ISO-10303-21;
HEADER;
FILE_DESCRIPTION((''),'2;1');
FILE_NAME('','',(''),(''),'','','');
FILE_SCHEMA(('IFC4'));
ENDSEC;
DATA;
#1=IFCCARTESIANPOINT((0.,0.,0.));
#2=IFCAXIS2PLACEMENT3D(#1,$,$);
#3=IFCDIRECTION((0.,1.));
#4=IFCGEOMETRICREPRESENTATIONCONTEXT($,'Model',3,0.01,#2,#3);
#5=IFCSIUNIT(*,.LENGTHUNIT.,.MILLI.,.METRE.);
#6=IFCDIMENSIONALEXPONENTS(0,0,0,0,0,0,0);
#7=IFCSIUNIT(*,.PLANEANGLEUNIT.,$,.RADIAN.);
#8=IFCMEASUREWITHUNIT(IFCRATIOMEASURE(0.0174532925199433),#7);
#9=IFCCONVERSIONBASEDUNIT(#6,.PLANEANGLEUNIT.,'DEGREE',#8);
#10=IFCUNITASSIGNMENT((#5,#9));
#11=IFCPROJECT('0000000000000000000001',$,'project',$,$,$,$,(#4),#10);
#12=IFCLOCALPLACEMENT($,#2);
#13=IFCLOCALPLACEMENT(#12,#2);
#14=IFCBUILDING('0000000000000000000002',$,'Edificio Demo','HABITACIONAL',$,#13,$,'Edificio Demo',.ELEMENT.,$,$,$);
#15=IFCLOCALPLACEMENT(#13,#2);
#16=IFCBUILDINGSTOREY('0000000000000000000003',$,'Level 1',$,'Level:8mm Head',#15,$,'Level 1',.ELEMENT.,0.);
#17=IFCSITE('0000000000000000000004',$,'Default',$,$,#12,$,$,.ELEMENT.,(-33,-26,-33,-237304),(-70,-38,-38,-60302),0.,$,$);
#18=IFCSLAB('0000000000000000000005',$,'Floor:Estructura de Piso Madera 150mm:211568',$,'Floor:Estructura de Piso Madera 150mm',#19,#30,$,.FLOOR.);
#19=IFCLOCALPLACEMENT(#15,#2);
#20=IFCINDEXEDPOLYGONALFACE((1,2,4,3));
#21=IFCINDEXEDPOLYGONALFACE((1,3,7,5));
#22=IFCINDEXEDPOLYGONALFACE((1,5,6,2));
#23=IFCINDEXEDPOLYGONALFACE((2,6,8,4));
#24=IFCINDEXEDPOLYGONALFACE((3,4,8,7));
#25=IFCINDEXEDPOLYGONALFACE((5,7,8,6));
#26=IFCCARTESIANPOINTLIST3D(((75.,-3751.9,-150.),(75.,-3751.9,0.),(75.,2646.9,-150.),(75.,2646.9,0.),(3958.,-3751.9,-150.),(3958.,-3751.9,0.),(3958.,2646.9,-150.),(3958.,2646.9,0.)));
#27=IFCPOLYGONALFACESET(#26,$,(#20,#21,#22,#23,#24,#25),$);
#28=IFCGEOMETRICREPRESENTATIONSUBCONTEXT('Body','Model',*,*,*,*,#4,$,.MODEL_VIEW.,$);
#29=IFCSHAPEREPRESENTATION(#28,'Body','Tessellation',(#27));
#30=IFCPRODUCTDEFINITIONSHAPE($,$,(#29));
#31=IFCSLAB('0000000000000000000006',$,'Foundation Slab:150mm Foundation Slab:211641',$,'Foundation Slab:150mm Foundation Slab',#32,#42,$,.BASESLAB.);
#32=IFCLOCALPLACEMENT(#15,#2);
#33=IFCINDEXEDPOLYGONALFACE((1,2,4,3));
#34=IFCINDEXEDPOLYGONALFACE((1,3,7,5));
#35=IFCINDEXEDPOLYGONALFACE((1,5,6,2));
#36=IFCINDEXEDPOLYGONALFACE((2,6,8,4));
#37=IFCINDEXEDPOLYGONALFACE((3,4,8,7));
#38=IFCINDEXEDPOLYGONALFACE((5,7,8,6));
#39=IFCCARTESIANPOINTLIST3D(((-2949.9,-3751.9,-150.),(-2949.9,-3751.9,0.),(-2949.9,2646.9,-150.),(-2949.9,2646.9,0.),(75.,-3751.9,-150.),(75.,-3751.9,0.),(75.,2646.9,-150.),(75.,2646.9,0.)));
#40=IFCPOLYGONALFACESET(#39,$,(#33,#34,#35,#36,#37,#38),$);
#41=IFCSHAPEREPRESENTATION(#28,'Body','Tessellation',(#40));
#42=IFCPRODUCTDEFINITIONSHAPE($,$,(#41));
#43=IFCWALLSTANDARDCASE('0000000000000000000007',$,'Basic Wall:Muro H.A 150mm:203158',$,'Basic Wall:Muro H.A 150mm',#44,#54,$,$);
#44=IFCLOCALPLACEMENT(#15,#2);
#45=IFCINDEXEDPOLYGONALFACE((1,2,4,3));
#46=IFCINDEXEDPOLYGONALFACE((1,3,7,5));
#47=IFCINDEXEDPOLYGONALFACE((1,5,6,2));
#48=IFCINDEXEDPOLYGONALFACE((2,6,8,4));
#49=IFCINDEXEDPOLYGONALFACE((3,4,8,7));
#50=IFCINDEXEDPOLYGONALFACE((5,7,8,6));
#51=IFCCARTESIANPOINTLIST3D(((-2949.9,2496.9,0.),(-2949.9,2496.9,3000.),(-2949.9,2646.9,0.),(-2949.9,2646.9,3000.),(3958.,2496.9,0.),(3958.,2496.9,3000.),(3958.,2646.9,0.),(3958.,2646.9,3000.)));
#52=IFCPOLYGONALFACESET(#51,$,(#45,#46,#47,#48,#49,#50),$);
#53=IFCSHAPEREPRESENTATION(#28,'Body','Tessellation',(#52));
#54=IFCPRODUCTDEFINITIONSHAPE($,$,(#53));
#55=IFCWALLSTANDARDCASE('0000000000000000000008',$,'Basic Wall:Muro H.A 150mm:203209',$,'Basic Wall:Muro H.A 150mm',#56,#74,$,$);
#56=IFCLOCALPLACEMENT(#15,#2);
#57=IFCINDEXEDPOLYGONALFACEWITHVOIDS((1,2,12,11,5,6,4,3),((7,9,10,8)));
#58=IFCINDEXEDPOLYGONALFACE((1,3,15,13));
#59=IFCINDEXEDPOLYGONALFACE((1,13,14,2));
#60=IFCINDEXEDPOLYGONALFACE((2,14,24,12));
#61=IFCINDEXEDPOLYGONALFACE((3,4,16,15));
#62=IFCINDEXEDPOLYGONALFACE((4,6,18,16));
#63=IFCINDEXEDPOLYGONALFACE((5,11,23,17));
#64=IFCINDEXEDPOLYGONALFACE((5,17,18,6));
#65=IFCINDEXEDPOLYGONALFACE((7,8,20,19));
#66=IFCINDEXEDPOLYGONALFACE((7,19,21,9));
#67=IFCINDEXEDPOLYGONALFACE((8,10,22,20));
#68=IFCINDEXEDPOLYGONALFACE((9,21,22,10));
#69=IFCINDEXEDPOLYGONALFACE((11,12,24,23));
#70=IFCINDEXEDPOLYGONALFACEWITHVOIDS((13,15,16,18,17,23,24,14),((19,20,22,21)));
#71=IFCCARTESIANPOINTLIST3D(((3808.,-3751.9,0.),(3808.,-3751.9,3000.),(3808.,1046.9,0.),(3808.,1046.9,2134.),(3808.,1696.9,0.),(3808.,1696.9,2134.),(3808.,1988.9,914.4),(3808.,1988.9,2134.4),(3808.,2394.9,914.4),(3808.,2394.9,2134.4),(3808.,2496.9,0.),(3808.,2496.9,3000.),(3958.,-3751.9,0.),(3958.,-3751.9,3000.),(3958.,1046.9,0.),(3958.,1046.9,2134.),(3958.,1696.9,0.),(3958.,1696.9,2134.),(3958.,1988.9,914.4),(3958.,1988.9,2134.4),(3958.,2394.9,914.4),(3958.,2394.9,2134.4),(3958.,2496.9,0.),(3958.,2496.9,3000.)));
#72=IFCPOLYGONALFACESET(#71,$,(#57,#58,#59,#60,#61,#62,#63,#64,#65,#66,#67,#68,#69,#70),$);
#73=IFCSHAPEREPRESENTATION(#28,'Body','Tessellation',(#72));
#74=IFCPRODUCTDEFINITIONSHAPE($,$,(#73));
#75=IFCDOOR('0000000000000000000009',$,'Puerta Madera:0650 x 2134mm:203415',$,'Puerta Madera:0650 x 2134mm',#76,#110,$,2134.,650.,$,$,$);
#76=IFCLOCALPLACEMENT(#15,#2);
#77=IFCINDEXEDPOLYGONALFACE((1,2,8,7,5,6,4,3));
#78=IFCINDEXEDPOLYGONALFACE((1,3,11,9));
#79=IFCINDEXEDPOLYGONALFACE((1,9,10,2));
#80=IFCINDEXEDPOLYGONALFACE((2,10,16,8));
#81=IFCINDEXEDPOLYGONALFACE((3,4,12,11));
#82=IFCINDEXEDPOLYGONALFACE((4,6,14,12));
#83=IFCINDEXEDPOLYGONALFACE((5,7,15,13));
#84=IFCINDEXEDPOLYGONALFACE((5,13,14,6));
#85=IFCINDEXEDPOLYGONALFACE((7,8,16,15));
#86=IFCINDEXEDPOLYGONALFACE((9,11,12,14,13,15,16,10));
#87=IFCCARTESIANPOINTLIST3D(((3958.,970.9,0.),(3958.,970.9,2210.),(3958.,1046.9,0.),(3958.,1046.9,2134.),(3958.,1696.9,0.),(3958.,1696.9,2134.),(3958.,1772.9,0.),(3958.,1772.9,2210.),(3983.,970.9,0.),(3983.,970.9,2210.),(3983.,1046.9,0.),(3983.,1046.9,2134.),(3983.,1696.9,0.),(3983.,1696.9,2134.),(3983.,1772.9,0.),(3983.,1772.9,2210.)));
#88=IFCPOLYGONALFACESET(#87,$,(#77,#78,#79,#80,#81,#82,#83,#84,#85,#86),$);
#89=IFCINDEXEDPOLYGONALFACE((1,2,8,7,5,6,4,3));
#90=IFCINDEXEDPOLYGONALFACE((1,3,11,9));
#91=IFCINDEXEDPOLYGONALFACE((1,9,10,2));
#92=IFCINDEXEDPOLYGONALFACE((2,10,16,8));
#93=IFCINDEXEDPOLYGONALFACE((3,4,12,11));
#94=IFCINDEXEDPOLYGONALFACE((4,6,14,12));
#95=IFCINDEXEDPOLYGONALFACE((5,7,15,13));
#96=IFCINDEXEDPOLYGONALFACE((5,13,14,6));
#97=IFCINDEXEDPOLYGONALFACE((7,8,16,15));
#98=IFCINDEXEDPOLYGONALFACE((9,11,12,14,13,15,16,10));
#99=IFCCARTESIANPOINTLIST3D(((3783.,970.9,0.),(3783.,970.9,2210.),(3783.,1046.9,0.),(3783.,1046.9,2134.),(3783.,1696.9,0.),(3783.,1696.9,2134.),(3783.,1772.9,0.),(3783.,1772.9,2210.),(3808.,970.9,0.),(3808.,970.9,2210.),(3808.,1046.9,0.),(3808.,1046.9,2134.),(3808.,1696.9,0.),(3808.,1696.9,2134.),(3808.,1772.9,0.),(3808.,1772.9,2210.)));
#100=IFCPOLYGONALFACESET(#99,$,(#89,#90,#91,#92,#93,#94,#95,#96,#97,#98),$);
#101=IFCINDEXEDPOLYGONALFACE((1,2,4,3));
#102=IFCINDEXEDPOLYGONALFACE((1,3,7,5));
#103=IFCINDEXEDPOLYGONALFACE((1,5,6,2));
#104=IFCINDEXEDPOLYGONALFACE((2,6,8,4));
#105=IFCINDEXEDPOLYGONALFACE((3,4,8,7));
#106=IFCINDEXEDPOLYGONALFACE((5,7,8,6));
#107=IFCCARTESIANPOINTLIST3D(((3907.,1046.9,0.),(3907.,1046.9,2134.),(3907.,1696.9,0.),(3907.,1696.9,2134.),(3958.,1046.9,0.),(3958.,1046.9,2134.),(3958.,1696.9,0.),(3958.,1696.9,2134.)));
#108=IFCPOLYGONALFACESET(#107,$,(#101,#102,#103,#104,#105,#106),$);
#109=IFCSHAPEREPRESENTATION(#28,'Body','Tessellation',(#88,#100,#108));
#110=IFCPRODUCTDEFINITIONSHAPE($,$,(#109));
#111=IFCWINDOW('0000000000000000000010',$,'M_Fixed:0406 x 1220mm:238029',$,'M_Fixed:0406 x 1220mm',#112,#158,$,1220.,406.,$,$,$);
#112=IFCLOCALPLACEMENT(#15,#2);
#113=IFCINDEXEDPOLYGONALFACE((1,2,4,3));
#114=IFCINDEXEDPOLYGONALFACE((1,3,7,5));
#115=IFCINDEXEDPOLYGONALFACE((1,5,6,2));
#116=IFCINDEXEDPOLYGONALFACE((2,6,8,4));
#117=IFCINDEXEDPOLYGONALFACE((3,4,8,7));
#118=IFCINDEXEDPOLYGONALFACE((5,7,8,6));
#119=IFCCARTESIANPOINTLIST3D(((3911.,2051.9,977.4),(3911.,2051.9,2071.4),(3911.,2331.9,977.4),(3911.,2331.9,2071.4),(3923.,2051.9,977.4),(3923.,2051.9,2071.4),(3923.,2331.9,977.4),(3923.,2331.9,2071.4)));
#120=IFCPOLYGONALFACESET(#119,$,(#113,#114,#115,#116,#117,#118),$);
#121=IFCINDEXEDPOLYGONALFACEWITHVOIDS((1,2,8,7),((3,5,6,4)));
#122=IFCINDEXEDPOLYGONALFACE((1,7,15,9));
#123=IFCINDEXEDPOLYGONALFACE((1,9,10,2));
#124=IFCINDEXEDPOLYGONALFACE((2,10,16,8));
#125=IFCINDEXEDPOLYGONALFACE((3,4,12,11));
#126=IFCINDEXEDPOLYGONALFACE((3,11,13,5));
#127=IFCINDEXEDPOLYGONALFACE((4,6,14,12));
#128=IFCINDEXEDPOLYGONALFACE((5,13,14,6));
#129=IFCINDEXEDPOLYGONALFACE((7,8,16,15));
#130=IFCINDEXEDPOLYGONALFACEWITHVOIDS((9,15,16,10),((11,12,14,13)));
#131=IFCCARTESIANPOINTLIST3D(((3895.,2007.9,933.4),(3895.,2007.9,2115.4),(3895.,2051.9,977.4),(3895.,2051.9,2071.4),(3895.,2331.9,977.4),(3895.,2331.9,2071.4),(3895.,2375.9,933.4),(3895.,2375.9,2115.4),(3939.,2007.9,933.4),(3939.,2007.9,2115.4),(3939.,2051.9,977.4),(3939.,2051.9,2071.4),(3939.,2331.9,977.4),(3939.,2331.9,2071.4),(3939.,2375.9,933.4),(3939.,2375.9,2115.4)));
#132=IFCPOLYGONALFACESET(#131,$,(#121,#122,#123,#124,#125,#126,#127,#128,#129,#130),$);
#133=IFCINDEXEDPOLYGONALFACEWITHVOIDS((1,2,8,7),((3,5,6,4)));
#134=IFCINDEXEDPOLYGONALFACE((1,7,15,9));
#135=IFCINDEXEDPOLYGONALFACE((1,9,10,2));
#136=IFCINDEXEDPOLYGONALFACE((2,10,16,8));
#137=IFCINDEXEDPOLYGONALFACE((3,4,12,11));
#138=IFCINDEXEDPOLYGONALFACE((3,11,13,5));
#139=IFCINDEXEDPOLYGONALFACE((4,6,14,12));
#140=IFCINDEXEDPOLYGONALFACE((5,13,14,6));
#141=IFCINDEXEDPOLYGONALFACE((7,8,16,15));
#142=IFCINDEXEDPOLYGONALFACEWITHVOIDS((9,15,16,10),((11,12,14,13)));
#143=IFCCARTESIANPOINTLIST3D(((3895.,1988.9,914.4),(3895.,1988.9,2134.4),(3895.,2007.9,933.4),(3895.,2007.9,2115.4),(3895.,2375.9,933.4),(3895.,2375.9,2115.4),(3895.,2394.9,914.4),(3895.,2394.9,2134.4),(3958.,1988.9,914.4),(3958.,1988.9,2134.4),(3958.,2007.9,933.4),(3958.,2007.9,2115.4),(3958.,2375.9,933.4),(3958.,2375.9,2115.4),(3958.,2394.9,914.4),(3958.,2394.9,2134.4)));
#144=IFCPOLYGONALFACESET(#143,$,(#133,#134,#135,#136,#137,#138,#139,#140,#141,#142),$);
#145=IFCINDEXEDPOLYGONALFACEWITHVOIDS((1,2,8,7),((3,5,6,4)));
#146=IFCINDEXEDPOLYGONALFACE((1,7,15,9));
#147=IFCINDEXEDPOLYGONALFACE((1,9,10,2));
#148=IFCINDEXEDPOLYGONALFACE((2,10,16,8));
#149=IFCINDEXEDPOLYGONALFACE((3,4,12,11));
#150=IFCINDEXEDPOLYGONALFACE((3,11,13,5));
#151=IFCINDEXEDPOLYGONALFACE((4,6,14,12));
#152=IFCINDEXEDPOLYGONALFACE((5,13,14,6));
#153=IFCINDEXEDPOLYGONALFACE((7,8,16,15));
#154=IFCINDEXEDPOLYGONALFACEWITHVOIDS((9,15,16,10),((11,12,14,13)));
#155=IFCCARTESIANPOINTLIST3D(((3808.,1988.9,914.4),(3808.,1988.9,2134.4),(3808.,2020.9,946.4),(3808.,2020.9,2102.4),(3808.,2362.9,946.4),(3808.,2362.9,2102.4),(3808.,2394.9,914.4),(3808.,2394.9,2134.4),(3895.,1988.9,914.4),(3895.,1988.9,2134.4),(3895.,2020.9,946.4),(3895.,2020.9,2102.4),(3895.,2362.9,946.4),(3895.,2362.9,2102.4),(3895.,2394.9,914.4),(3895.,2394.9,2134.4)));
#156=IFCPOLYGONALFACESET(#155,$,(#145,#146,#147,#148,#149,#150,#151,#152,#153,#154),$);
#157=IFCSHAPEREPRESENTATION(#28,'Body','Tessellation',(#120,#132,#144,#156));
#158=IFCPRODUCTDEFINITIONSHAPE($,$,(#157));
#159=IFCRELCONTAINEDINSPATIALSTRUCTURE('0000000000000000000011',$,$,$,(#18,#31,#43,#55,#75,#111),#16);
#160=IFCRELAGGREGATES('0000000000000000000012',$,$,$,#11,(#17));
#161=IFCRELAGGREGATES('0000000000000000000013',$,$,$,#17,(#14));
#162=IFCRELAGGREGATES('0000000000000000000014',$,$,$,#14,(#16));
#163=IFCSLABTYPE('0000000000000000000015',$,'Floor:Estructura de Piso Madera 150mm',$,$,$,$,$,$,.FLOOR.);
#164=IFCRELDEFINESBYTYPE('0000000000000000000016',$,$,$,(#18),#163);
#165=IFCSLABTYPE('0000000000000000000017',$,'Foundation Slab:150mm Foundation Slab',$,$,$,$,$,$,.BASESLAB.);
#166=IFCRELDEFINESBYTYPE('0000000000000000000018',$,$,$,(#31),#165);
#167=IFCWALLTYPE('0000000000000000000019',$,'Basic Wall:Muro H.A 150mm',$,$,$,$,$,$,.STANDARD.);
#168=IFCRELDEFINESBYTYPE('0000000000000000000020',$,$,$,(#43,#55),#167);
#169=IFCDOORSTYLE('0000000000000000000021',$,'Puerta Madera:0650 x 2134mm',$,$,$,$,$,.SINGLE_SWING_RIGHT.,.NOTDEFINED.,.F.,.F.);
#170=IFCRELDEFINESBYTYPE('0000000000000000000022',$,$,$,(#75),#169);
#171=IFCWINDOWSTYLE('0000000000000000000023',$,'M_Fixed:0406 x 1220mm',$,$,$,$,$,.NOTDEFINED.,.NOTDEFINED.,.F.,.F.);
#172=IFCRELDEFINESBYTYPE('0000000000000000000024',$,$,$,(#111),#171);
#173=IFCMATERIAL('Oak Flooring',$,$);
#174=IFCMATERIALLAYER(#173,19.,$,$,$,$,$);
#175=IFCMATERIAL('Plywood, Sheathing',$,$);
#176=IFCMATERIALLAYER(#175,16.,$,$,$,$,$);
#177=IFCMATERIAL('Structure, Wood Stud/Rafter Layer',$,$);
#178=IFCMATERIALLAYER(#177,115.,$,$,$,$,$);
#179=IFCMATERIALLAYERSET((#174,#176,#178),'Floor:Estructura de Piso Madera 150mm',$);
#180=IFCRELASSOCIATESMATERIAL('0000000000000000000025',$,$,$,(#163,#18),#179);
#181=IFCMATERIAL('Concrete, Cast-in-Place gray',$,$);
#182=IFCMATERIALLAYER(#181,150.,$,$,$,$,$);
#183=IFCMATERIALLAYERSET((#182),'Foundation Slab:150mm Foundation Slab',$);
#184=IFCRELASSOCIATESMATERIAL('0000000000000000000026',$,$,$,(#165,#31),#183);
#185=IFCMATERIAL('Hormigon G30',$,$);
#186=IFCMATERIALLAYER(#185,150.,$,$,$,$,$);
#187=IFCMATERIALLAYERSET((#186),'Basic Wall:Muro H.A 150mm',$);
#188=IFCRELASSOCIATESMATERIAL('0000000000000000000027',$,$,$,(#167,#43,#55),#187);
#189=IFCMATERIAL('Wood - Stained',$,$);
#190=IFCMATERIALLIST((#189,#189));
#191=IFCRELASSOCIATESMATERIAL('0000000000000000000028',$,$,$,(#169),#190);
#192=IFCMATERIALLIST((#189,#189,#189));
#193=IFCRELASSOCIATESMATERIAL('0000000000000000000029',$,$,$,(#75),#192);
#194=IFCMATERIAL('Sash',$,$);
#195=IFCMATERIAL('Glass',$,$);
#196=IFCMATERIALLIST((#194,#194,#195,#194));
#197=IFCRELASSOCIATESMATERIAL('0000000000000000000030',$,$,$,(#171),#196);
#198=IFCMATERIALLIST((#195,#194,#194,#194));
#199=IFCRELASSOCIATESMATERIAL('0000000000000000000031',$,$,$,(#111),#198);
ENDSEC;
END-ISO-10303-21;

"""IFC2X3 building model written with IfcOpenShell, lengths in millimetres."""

from ifc_helpers import new_model, entity, si_unit, converted_unit, direction, frame, frame_2d, origin, origin_2d_with_axis, place, context, subcontext, project, spatial, polyline, rectangle, outline, extrude, source, transform, mapped, material, material_list, layer, layer_set, layer_usage, type_object, type_shapes, element, fill, save


model = new_model("IFC2X3")

# Units and contexts
model_context = context("Model", 3, precision=0.01, world=origin(), true_north=direction((0.0, 1.0)))
body_context = subcontext(model_context, "Body", "Model", "MODEL_VIEW")
ifc_project = project(units=[si_unit("LENGTHUNIT", "METRE", prefix="MILLI"), converted_unit("PLANEANGLEUNIT", "DEGREE", entity("IfcRatioMeasure", 0.0174532925199433), si_unit("PLANEANGLEUNIT", "RADIAN"), dimensions=[0, 0, 0, 0, 0, 0, 0])], contexts=[model_context])

# Site, building, storey
site_placement = place(None, origin())
site = spatial("IfcSite", under=ifc_project, at=site_placement, Name="Default", CompositionType="ELEMENT", RefLatitude=(-33, -26, -33, -237304), RefLongitude=(-70, -38, -38, -60302), RefElevation=0.0)
building_placement = place(site_placement, origin())
building = spatial("IfcBuilding", under=site, at=building_placement, Name="Edificio Demo", Description="HABITACIONAL", LongName="Edificio Demo", CompositionType="ELEMENT")
storey_placement = place(building_placement, origin())
storey = spatial("IfcBuildingStorey", under=building, at=storey_placement, Name="Level 1", ObjectType="Level:8mm Head", LongName="Level 1", CompositionType="ELEMENT", Elevation=0.0)

# Slabs
ifc_material_1 = material(Name="Oak Flooring")
ifc_layer_1 = layer(ifc_material_1, 19.0)
ifc_material_2 = material(Name="Plywood, Sheathing")
ifc_layer_2 = layer(ifc_material_2, 16.0)
ifc_material_3 = material(Name="Structure, Wood Stud/Rafter Layer")
ifc_layer_3 = layer(ifc_material_3, 115.0)
ifc_layer_set_1 = layer_set([ifc_layer_1, ifc_layer_2, ifc_layer_3], Name="Floor:Estructura de Piso Madera 150mm")
ifc_layer_usage_1 = layer_usage(ifc_layer_set_1, "AXIS3", "POSITIVE", 0.0)
slab_type_1 = type_object("IfcSlabType", Name="Floor:Estructura de Piso Madera 150mm", PredefinedType="FLOOR", material=ifc_layer_set_1)
slab_1_placement = place(storey_placement, origin())
element("IfcSlab", 1, at=slab_1_placement, inside=storey, type_object=slab_type_1, material=ifc_layer_usage_1, Name="Floor:Estructura de Piso Madera 150mm:211568", ObjectType="Floor:Estructura de Piso Madera 150mm", PredefinedType="FLOOR", context=body_context, shape_type="SweptSolid", body=[
    extrude(rectangle(XDim=6398.8, YDim=3883.0, at=frame_2d((0.0, 0.0), x_axis=(1.0, 0.0))), frame((2016.5, -552.5, 0.0), z_axis=(0.0, 0.0, -1.0), x_axis=(0.0, 1.0, 0.0)), (0.0, 0.0, 1.0), 150.0),
])
ifc_material_4 = material(Name="Concrete, Cast-in-Place gray")
ifc_layer_4 = layer(ifc_material_4, 150.0)
ifc_layer_set_2 = layer_set([ifc_layer_4], Name="Foundation Slab:150mm Foundation Slab")
ifc_layer_usage_2 = layer_usage(ifc_layer_set_2, "AXIS3", "POSITIVE", 0.0)
slab_type_2 = type_object("IfcSlabType", Name="Foundation Slab:150mm Foundation Slab", PredefinedType="BASESLAB", material=ifc_layer_set_2)
slab_2_placement = place(storey_placement, origin())
element("IfcSlab", 2, at=slab_2_placement, inside=storey, type_object=slab_type_2, material=ifc_layer_usage_2, Name="Foundation Slab:150mm Foundation Slab:211641", ObjectType="Foundation Slab:150mm Foundation Slab", PredefinedType="BASESLAB", context=body_context, shape_type="SweptSolid", body=[
    extrude(rectangle(XDim=6398.8, YDim=3024.9, at=frame_2d((0.0, 0.0), x_axis=(1.0, 0.0))), frame((-1437.4, -552.5, 0.0), z_axis=(0.0, 0.0, -1.0), x_axis=(0.0, 1.0, 0.0)), (0.0, 0.0, 1.0), 150.0),
])

# Wall
ifc_material_5 = material(Name="Hormigon G30")
ifc_layer_5 = layer(ifc_material_5, 150.0)
ifc_layer_set_3 = layer_set([ifc_layer_5], Name="Basic Wall:Muro H.A 150mm")
ifc_layer_usage_3 = layer_usage(ifc_layer_set_3, "AXIS2", "NEGATIVE", 75.0)
wall_type_1 = type_object("IfcWallType", Name="Basic Wall:Muro H.A 150mm", PredefinedType="STANDARD", material=ifc_layer_set_3)
wall_1_placement = place(storey_placement, frame((-2949.9, 2571.9, 0.0)))
element("IfcWallStandardCase", 3, at=wall_1_placement, inside=storey, type_object=wall_type_1, material=ifc_layer_usage_3, Name="Basic Wall:Muro H.A 150mm:203158", ObjectType="Basic Wall:Muro H.A 150mm", context=body_context, shape_type="SweptSolid", body=[
    extrude(rectangle(XDim=6907.9, YDim=150.0, at=frame_2d((3453.9, 0.0), x_axis=(-1.0, 0.0))), origin(), (0.0, 0.0, 1.0), 3000.0),
])

# Wall, openings, door, window
ifc_layer_usage_4 = layer_usage(ifc_layer_set_3, "AXIS2", "NEGATIVE", 75.0)
wall_2_placement = place(storey_placement, frame((3883.0, 2496.9, 0.0), z_axis=(0.0, 0.0, 1.0), x_axis=(0.0, -1.0, 0.0)))
wall_2 = element("IfcWallStandardCase", 4, at=wall_2_placement, inside=storey, type_object=wall_type_1, material=ifc_layer_usage_4, Name="Basic Wall:Muro H.A 150mm:203209", ObjectType="Basic Wall:Muro H.A 150mm", context=body_context, shape_type="SweptSolid", body=[
    extrude(rectangle(XDim=6248.8, YDim=150.0, at=frame_2d((3124.4, 0.0), x_axis=(-1.0, 0.0))), origin(), (0.0, 0.0, 1.0), 3000.0),
])
opening_1_placement = place(wall_2_placement, frame((800.0, -75.0, 0.0)))
opening_1 = element("IfcOpeningElement", 5, at=opening_1_placement, cuts=wall_2, ObjectType="Opening", context=body_context, shape_type="SweptSolid", body=[
    extrude(rectangle(XDim=650.0, YDim=2134.0, at=frame_2d((1067.0, 325.0), x_axis=(0.0, 1.0))), frame((0.0, 0.0, 0.0), z_axis=(0.0, 1.0, 0.0), x_axis=(0.0, 0.0, 1.0)), (0.0, 0.0, 1.0), 150.0),
])
opening_2_placement = place(wall_2_placement, frame((102.0, -75.0, 914.4)))
opening_2 = element("IfcOpeningElement", 6, at=opening_2_placement, cuts=wall_2, ObjectType="Opening", context=body_context, shape_type="SweptSolid", body=[
    extrude(rectangle(XDim=1220.0, YDim=406.0, at=frame_2d((610.0, 203.0), x_axis=(1.0, 0.0))), frame((0.0, 0.0, 0.0), z_axis=(0.0, 1.0, 0.0), x_axis=(0.0, 0.0, 1.0)), (0.0, 0.0, 1.0), 150.0),
])
ifc_material_6 = material(Name="Wood - Stained")
ifc_material_list_1 = material_list([ifc_material_6, ifc_material_6, ifc_material_6])
ifc_material_list_2 = material_list([ifc_material_6, ifc_material_6])
door_style_1 = type_object("IfcDoorStyle", Name="Puerta Madera:0650 x 2134mm", ConstructionType="NOTDEFINED", OperationType="SINGLE_SWING_RIGHT", ParameterTakesPrecedence=False, Sizeable=False, material=ifc_material_list_2)
shared_shape_1 = source(origin(), body_context, "Body", "SweptSolid", [
    extrude(outline(polyline([(-401.0, -1124.0), (401.0, -1124.0), (401.0, 1086.0), (325.0, 1086.0), (325.0, -1048.0), (-325.0, -1048.0), (-325.0, 1086.0), (-401.0, 1086.0), (-401.0, -1124.0)])), frame((325.0, 150.0, 1086.0), z_axis=(0.0, 1.0, 0.0), x_axis=(1.0, 0.0, 0.0)), (0.0, 0.0, 1.0), 25.0),
    extrude(outline(polyline([(-1124.0, -401.0), (1086.0, -401.0), (1086.0, -325.0), (-1048.0, -325.0), (-1048.0, 325.0), (1086.0, 325.0), (1086.0, 401.0), (-1124.0, 401.0), (-1124.0, -401.0)])), frame((325.0, -25.0, 1086.0), z_axis=(0.0, 1.0, 0.0), x_axis=(0.0, 0.0, -1.0)), (0.0, 0.0, 1.0), 25.0),
    extrude(rectangle(XDim=51.0, YDim=650.0, at=frame_2d((0.0, 0.0), x_axis=(1.0, 0.0))), frame((325.0, 124.5, 0.0), z_axis=(0.0, 0.0, 1.0), x_axis=(0.0, 1.0, 0.0)), (0.0, 0.0, 1.0), 2134.0),
])
type_shapes(door_style_1, [shared_shape_1])
door_1_placement = place(opening_1_placement, origin())
door_1 = element("IfcDoor", 7, at=door_1_placement, inside=storey, type_object=door_style_1, material=ifc_material_list_1, Name="Puerta Madera:0650 x 2134mm:203415", ObjectType="Puerta Madera:0650 x 2134mm", OverallHeight=2134.0, OverallWidth=650.0, context=body_context, shape_type="MappedRepresentation", body=[
    mapped(shared_shape_1, transform((0.0, 0.0, 0.0), scale=1.0)),
])
fill(opening_1, door_1)
ifc_material_7 = material(Name="Glass")
ifc_material_8 = material(Name="Sash")
ifc_material_list_3 = material_list([ifc_material_7, ifc_material_8, ifc_material_8, ifc_material_8])
ifc_material_list_4 = material_list([ifc_material_8, ifc_material_8, ifc_material_7, ifc_material_8])
window_style_1 = type_object("IfcWindowStyle", Name="M_Fixed:0406 x 1220mm", ConstructionType="NOTDEFINED", OperationType="NOTDEFINED", ParameterTakesPrecedence=False, Sizeable=False, material=ifc_material_list_4)
shared_shape_2 = source(origin(), body_context, "Body", "SweptSolid", [
    extrude(rectangle(XDim=12.0, YDim=280.0, at=origin_2d_with_axis()), frame((203.0, 109.0, 63.0), z_axis=(0.0, 0.0, 1.0), x_axis=(0.0, -1.0, 0.0)), (0.0, 0.0, 1.0), 1094.0),
    extrude(outline(polyline([(-184.0, -591.0), (184.0, -591.0), (184.0, 591.0), (-184.0, 591.0), (-184.0, -591.0)]), holes=[polyline([(-140.0, -547.0), (-140.0, 547.0), (140.0, 547.0), (140.0, -547.0), (-140.0, -547.0)])]), frame((203.0, 87.0, 610.0), z_axis=(0.0, 1.0, 0.0), x_axis=(1.0, 0.0, 0.0)), (0.0, 0.0, 1.0), 44.0),
    extrude(outline(polyline([(-203.0, -610.0), (203.0, -610.0), (203.0, 610.0), (-203.0, 610.0), (-203.0, -610.0)]), holes=[polyline([(-184.0, -591.0), (-184.0, 591.0), (184.0, 591.0), (184.0, -591.0), (-184.0, -591.0)])]), frame((203.0, 87.0, 610.0), z_axis=(0.0, 1.0, 0.0), x_axis=(1.0, 0.0, 0.0)), (0.0, 0.0, 1.0), 63.0),
    extrude(outline(polyline([(-203.0, -610.0), (203.0, -610.0), (203.0, 610.0), (-203.0, 610.0), (-203.0, -610.0)]), holes=[polyline([(-171.0, -578.0), (-171.0, 578.0), (171.0, 578.0), (171.0, -578.0), (-171.0, -578.0)])]), frame((203.0, 0.0, 610.0), z_axis=(0.0, 1.0, 0.0), x_axis=(1.0, 0.0, 0.0)), (0.0, 0.0, 1.0), 87.0),
])
type_shapes(window_style_1, [shared_shape_2])
window_1_placement = place(opening_2_placement, origin())
window_1 = element("IfcWindow", 8, at=window_1_placement, inside=storey, type_object=window_style_1, material=ifc_material_list_3, Name="M_Fixed:0406 x 1220mm:238029", ObjectType="M_Fixed:0406 x 1220mm", OverallHeight=1220.0, OverallWidth=406.0, context=body_context, shape_type="MappedRepresentation", body=[
    mapped(shared_shape_2, transform((0.0, 0.0, 0.0), scale=1.0)),
])
fill(opening_2, window_1)

save(model, "model.ifc")
